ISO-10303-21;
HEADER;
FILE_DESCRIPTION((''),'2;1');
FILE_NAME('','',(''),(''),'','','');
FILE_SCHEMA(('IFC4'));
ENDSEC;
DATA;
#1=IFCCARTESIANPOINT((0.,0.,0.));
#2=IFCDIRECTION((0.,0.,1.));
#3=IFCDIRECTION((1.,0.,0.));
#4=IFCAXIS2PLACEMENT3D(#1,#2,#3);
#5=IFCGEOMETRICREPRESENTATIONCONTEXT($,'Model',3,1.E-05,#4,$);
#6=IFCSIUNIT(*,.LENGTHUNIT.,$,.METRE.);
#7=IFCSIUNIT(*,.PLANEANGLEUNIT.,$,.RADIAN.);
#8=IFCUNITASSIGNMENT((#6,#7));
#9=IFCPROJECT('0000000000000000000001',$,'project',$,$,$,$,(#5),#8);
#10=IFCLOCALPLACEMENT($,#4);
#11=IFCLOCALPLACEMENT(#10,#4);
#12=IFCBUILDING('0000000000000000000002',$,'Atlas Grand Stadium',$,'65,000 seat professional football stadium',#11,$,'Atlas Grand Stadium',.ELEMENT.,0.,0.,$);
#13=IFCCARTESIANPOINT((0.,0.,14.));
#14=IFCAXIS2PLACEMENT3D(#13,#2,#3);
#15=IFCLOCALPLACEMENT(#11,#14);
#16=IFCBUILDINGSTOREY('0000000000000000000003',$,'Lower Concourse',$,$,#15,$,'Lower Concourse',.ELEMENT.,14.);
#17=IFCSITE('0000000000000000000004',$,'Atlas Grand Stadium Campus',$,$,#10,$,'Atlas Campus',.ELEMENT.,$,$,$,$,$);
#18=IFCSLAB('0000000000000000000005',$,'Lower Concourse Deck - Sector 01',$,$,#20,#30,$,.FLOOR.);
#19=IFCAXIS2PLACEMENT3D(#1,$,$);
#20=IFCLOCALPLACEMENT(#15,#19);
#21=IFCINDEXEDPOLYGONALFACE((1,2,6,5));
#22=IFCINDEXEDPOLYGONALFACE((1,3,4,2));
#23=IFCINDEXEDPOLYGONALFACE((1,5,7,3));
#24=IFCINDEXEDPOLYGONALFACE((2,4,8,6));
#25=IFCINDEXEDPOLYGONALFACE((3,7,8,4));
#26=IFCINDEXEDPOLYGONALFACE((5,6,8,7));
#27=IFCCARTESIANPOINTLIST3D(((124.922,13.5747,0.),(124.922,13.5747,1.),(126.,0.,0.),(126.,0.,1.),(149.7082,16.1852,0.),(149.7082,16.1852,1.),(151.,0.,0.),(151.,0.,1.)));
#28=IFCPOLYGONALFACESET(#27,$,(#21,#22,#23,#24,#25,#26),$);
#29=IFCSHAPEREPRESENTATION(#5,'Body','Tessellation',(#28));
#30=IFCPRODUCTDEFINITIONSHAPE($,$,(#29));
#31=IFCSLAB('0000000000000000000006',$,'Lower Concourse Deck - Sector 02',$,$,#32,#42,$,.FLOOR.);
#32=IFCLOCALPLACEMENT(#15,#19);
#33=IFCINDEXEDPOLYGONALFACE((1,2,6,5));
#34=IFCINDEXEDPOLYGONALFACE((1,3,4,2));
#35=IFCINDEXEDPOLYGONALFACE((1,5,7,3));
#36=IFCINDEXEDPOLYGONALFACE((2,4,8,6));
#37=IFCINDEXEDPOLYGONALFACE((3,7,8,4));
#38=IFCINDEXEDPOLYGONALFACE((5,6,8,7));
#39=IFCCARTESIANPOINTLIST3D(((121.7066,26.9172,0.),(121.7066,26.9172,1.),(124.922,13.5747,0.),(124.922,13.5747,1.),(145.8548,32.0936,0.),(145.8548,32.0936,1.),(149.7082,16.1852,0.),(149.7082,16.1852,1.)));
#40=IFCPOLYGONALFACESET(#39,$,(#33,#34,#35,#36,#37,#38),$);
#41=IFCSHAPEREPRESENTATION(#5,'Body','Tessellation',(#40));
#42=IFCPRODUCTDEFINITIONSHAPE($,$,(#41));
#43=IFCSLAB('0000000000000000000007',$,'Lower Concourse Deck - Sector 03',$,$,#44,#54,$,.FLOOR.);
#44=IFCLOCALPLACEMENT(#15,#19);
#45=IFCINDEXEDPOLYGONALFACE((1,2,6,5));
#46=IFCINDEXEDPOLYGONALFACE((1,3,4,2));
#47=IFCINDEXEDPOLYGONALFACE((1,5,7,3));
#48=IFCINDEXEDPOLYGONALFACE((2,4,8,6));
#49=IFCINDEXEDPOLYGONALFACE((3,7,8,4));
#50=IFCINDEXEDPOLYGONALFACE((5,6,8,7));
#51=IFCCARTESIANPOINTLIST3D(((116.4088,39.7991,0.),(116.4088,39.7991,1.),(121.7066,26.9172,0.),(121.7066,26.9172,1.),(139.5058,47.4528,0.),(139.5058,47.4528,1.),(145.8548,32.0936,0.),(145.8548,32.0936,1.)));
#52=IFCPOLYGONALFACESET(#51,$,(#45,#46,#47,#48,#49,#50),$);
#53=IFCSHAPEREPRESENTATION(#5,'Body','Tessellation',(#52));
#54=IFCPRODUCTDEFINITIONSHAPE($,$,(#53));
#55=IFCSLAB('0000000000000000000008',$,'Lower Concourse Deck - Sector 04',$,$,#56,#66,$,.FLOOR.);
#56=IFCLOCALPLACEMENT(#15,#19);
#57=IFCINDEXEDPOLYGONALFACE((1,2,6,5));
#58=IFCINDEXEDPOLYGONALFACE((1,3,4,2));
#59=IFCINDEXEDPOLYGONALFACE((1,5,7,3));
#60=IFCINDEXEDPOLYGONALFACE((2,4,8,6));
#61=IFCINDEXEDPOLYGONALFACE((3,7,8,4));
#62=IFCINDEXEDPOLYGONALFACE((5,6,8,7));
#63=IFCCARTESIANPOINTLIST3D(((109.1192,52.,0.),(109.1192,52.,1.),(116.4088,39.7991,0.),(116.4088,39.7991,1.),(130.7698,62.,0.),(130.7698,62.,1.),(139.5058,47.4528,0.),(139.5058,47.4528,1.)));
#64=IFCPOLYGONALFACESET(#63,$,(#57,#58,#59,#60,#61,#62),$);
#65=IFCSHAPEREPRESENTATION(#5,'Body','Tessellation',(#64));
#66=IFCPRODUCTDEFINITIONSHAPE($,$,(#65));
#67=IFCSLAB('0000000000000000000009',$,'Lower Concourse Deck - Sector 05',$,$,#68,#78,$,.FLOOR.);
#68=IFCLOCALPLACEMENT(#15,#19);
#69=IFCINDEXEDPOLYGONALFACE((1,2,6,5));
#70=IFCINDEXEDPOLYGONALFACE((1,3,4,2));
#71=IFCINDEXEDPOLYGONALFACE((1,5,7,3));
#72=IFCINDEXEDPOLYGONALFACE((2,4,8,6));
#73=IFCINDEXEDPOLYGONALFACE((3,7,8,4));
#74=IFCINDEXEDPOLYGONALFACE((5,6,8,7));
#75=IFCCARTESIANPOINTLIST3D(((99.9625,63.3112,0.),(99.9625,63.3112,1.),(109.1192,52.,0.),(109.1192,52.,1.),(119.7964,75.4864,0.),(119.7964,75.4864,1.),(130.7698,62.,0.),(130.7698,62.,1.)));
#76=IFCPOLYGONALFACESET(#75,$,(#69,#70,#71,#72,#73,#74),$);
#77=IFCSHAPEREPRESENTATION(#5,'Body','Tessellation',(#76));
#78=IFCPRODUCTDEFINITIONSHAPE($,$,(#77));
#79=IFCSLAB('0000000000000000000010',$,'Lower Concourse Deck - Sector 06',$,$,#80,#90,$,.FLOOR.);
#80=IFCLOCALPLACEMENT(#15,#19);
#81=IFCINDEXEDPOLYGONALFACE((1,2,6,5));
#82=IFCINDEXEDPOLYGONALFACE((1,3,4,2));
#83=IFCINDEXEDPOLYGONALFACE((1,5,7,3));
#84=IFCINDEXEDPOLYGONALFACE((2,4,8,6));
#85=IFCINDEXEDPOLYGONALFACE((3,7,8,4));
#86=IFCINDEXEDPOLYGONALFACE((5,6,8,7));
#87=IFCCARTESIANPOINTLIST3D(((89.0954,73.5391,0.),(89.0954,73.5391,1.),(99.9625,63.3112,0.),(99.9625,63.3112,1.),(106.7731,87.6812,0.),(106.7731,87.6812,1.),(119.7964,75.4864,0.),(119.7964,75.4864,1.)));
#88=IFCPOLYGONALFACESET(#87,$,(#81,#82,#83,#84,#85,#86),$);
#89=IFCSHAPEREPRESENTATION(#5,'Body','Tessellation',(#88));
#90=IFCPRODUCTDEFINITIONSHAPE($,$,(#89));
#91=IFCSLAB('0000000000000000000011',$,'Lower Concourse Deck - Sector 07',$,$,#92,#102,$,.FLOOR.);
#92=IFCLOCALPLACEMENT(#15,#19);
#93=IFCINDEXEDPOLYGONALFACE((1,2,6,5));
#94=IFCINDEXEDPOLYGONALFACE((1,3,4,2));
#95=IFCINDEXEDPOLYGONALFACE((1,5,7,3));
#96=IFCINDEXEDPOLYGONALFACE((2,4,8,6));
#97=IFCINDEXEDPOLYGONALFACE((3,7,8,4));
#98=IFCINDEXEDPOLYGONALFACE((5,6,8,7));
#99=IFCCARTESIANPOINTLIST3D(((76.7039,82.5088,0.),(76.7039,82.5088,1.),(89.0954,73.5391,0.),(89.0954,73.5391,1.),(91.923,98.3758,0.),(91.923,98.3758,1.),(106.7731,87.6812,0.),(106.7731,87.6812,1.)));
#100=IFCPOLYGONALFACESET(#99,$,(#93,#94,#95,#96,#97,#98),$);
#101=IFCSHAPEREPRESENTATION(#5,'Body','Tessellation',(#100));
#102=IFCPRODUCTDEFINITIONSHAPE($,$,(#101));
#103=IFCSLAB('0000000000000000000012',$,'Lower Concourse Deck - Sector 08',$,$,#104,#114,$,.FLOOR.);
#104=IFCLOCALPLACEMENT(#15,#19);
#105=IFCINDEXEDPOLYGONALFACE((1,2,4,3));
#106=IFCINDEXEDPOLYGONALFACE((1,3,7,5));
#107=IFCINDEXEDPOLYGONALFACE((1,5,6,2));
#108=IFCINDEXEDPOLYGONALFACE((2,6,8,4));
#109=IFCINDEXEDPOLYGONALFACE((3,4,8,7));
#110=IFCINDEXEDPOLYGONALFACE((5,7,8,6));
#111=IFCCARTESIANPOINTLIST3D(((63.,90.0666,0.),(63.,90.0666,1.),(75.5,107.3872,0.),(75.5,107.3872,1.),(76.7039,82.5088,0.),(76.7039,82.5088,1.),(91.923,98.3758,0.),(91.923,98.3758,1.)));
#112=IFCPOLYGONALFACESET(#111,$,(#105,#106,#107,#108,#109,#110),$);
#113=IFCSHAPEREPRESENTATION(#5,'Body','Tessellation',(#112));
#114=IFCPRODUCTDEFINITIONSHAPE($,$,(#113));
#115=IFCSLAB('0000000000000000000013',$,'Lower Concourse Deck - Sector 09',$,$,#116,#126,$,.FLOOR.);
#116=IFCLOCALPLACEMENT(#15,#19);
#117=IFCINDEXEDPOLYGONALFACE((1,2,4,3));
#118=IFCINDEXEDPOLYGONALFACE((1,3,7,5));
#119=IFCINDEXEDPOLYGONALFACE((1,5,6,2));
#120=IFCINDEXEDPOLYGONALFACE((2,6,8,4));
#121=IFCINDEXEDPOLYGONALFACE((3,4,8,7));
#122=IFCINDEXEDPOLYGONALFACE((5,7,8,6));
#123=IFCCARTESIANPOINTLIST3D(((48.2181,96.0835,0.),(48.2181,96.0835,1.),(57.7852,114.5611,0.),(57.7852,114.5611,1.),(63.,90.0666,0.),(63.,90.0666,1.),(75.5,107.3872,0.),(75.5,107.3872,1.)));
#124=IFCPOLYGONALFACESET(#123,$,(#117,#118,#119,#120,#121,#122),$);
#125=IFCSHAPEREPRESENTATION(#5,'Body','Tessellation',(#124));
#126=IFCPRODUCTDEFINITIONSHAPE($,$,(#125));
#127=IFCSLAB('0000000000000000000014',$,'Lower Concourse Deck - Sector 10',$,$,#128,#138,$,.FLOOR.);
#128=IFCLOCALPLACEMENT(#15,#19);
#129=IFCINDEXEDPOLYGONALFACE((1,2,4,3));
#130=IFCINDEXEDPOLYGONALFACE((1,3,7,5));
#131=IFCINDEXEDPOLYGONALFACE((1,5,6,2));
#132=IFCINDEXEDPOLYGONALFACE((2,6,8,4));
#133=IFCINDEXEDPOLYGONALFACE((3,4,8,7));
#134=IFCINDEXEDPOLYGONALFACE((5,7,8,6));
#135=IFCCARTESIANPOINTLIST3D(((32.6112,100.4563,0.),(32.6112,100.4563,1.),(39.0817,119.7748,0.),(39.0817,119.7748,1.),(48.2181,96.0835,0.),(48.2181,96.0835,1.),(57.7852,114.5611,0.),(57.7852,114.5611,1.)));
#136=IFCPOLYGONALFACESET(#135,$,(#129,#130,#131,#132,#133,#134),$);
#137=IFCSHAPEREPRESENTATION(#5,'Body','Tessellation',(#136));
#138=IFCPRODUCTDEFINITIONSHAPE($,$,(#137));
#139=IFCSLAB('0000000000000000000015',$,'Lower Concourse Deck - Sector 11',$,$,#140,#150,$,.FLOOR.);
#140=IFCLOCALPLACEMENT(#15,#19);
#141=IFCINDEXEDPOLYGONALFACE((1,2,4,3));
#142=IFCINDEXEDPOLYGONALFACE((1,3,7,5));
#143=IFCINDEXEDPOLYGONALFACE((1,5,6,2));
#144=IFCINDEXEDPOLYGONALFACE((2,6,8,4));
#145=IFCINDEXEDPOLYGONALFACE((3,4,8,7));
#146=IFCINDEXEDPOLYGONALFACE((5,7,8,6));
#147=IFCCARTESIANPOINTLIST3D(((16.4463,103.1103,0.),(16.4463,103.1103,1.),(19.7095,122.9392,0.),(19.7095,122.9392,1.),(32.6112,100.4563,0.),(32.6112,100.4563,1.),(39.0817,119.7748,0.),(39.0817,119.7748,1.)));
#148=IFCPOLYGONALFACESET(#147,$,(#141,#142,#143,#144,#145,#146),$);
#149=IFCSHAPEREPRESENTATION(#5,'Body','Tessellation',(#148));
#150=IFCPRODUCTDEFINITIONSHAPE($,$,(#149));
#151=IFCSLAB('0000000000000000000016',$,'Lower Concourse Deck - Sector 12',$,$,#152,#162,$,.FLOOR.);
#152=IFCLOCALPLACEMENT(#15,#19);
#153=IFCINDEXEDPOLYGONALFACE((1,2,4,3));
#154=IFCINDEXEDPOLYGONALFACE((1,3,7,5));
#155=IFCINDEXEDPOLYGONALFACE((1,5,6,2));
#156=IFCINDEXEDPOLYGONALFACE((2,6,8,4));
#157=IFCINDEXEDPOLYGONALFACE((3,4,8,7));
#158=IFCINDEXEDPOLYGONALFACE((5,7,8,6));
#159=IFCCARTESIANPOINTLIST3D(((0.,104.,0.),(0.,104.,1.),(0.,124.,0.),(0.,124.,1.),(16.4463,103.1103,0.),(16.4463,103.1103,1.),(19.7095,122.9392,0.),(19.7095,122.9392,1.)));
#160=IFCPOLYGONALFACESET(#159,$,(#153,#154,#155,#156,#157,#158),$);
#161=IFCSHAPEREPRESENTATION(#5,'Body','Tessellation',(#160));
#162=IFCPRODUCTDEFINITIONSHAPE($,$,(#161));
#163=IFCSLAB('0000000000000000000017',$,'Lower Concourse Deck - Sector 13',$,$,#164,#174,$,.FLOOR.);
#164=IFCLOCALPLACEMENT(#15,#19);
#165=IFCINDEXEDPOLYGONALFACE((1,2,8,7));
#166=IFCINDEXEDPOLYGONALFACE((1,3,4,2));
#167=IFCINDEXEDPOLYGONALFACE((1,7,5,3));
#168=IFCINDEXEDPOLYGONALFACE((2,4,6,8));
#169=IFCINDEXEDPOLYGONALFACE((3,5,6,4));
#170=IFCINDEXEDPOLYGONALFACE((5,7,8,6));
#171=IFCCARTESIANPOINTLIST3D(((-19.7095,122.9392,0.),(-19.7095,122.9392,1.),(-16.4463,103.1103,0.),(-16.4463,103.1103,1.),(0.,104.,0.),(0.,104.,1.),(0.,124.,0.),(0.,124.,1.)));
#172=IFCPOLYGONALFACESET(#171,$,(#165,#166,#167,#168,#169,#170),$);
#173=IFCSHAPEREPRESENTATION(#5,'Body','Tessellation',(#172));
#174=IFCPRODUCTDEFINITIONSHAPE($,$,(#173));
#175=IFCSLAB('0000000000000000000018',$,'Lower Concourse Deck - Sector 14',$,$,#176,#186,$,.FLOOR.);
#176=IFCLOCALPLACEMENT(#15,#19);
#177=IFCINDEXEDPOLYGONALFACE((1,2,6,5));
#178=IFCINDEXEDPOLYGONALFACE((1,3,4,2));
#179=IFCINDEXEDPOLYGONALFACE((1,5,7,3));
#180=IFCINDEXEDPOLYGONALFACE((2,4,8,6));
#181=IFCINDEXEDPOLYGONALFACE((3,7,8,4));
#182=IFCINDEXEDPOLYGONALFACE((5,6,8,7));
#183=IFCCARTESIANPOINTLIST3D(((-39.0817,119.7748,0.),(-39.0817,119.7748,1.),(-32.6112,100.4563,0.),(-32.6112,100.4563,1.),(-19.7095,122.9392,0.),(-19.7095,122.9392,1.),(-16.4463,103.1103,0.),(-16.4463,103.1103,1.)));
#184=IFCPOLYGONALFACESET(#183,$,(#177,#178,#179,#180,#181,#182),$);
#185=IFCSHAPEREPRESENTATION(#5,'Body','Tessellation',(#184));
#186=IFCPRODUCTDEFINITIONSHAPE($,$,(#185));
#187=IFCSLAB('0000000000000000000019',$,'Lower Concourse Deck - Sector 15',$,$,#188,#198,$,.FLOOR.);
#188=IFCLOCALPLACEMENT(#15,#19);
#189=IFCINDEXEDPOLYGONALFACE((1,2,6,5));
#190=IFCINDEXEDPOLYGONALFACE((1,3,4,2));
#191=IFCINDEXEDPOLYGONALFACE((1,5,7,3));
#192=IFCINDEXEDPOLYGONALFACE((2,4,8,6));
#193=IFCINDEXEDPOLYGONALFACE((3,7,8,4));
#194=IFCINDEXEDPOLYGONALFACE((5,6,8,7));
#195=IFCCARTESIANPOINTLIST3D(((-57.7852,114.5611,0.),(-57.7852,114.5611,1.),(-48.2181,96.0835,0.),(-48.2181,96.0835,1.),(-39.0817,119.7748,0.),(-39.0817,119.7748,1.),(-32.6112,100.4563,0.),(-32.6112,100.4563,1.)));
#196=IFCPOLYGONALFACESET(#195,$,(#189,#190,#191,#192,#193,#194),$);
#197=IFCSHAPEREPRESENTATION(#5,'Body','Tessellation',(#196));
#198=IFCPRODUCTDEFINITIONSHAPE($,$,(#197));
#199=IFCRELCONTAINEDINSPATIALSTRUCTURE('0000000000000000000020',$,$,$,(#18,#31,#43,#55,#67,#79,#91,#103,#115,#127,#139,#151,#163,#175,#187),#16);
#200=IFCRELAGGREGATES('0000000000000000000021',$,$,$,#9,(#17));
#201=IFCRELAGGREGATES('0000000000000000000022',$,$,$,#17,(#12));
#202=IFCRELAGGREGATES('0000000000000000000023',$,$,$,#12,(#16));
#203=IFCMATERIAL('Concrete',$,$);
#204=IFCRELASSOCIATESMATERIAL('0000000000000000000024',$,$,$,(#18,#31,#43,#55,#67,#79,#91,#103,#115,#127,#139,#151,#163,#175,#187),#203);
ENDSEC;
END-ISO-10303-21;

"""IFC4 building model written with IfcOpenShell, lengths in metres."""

from ifc_helpers import new_model, si_unit, frame, origin_with_axes, place, context, project, spatial, polyline, outline, extrude, material, element, save


model = new_model("IFC4")

# Units and contexts
model_context = context("Model", 3, precision=1e-05, world=origin_with_axes())
ifc_project = project(units=[si_unit("LENGTHUNIT", "METRE"), si_unit("PLANEANGLEUNIT", "RADIAN")], contexts=[model_context])

# Site, building, storey
site_placement = place(None, origin_with_axes())
site = spatial("IfcSite", under=ifc_project, at=site_placement, Name="Atlas Grand Stadium Campus", LongName="Atlas Campus", CompositionType="ELEMENT")
building_placement = place(site_placement, origin_with_axes())
building = spatial("IfcBuilding", under=site, at=building_placement, Name="Atlas Grand Stadium", ObjectType="65,000 seat professional football stadium", LongName="Atlas Grand Stadium", CompositionType="ELEMENT", ElevationOfRefHeight=0.0, ElevationOfTerrain=0.0)
storey_placement = place(building_placement, frame((0.0, 0.0, 14.0), z_axis=(0.0, 0.0, 1.0), x_axis=(1.0, 0.0, 0.0)))
storey = spatial("IfcBuildingStorey", under=building, at=storey_placement, Name="Lower Concourse", LongName="Lower Concourse", CompositionType="ELEMENT", Elevation=14.0)

# Slabs
ifc_material = material(Name="Concrete")
slab_1_placement = place(storey_placement, origin_with_axes())
element("IfcSlab", 1, at=slab_1_placement, inside=storey, material=ifc_material, Name="Lower Concourse Deck - Sector 01", PredefinedType="FLOOR", context=model_context, shape_type="SweptSolid", body=[
    extrude(outline(polyline([(151.0, 0.0), (149.7082, 16.1852), (124.922, 13.5747), (126.0, 0.0), (151.0, 0.0)])), origin_with_axes(), (0.0, 0.0, 1.0), 1.0),
])
slab_2_placement = place(storey_placement, origin_with_axes())
element("IfcSlab", 2, at=slab_2_placement, inside=storey, material=ifc_material, Name="Lower Concourse Deck - Sector 02", PredefinedType="FLOOR", context=model_context, shape_type="SweptSolid", body=[
    extrude(outline(polyline([(149.7082, 16.1852), (145.8548, 32.0936), (121.7066, 26.9172), (124.922, 13.5747), (149.7082, 16.1852)])), origin_with_axes(), (0.0, 0.0, 1.0), 1.0),
])
slab_3_placement = place(storey_placement, origin_with_axes())
element("IfcSlab", 3, at=slab_3_placement, inside=storey, material=ifc_material, Name="Lower Concourse Deck - Sector 03", PredefinedType="FLOOR", context=model_context, shape_type="SweptSolid", body=[
    extrude(outline(polyline([(145.8548, 32.0936), (139.5058, 47.4528), (116.4088, 39.7991), (121.7066, 26.9172), (145.8548, 32.0936)])), origin_with_axes(), (0.0, 0.0, 1.0), 1.0),
])
slab_4_placement = place(storey_placement, origin_with_axes())
element("IfcSlab", 4, at=slab_4_placement, inside=storey, material=ifc_material, Name="Lower Concourse Deck - Sector 04", PredefinedType="FLOOR", context=model_context, shape_type="SweptSolid", body=[
    extrude(outline(polyline([(139.5058, 47.4528), (130.7698, 62.0), (109.1192, 52.0), (116.4088, 39.7991), (139.5058, 47.4528)])), origin_with_axes(), (0.0, 0.0, 1.0), 1.0),
])
slab_5_placement = place(storey_placement, origin_with_axes())
element("IfcSlab", 5, at=slab_5_placement, inside=storey, material=ifc_material, Name="Lower Concourse Deck - Sector 05", PredefinedType="FLOOR", context=model_context, shape_type="SweptSolid", body=[
    extrude(outline(polyline([(130.7698, 62.0), (119.7964, 75.4864), (99.9625, 63.3112), (109.1192, 52.0), (130.7698, 62.0)])), origin_with_axes(), (0.0, 0.0, 1.0), 1.0),
])
slab_6_placement = place(storey_placement, origin_with_axes())
element("IfcSlab", 6, at=slab_6_placement, inside=storey, material=ifc_material, Name="Lower Concourse Deck - Sector 06", PredefinedType="FLOOR", context=model_context, shape_type="SweptSolid", body=[
    extrude(outline(polyline([(119.7964, 75.4864), (106.7731, 87.6812), (89.0954, 73.5391), (99.9625, 63.3112), (119.7964, 75.4864)])), origin_with_axes(), (0.0, 0.0, 1.0), 1.0),
])
slab_7_placement = place(storey_placement, origin_with_axes())
element("IfcSlab", 7, at=slab_7_placement, inside=storey, material=ifc_material, Name="Lower Concourse Deck - Sector 07", PredefinedType="FLOOR", context=model_context, shape_type="SweptSolid", body=[
    extrude(outline(polyline([(106.7731, 87.6812), (91.923, 98.3758), (76.7039, 82.5088), (89.0954, 73.5391), (106.7731, 87.6812)])), origin_with_axes(), (0.0, 0.0, 1.0), 1.0),
])
slab_8_placement = place(storey_placement, origin_with_axes())
element("IfcSlab", 8, at=slab_8_placement, inside=storey, material=ifc_material, Name="Lower Concourse Deck - Sector 08", PredefinedType="FLOOR", context=model_context, shape_type="SweptSolid", body=[
    extrude(outline(polyline([(91.923, 98.3758), (75.5, 107.3872), (63.0, 90.0666), (76.7039, 82.5088), (91.923, 98.3758)])), origin_with_axes(), (0.0, 0.0, 1.0), 1.0),
])
slab_9_placement = place(storey_placement, origin_with_axes())
element("IfcSlab", 9, at=slab_9_placement, inside=storey, material=ifc_material, Name="Lower Concourse Deck - Sector 09", PredefinedType="FLOOR", context=model_context, shape_type="SweptSolid", body=[
    extrude(outline(polyline([(75.5, 107.3872), (57.7852, 114.5611), (48.2181, 96.0835), (63.0, 90.0666), (75.5, 107.3872)])), origin_with_axes(), (0.0, 0.0, 1.0), 1.0),
])
slab_10_placement = place(storey_placement, origin_with_axes())
element("IfcSlab", 10, at=slab_10_placement, inside=storey, material=ifc_material, Name="Lower Concourse Deck - Sector 10", PredefinedType="FLOOR", context=model_context, shape_type="SweptSolid", body=[
    extrude(outline(polyline([(57.7852, 114.5611), (39.0817, 119.7748), (32.6112, 100.4563), (48.2181, 96.0835), (57.7852, 114.5611)])), origin_with_axes(), (0.0, 0.0, 1.0), 1.0),
])
slab_11_placement = place(storey_placement, origin_with_axes())
element("IfcSlab", 11, at=slab_11_placement, inside=storey, material=ifc_material, Name="Lower Concourse Deck - Sector 11", PredefinedType="FLOOR", context=model_context, shape_type="SweptSolid", body=[
    extrude(outline(polyline([(39.0817, 119.7748), (19.7095, 122.9392), (16.4463, 103.1103), (32.6112, 100.4563), (39.0817, 119.7748)])), origin_with_axes(), (0.0, 0.0, 1.0), 1.0),
])
slab_12_placement = place(storey_placement, origin_with_axes())
element("IfcSlab", 12, at=slab_12_placement, inside=storey, material=ifc_material, Name="Lower Concourse Deck - Sector 12", PredefinedType="FLOOR", context=model_context, shape_type="SweptSolid", body=[
    extrude(outline(polyline([(19.7095, 122.9392), (0.0, 124.0), (0.0, 104.0), (16.4463, 103.1103), (19.7095, 122.9392)])), origin_with_axes(), (0.0, 0.0, 1.0), 1.0),
])
slab_13_placement = place(storey_placement, origin_with_axes())
element("IfcSlab", 13, at=slab_13_placement, inside=storey, material=ifc_material, Name="Lower Concourse Deck - Sector 13", PredefinedType="FLOOR", context=model_context, shape_type="SweptSolid", body=[
    extrude(outline(polyline([(0.0, 124.0), (-19.7095, 122.9392), (-16.4463, 103.1103), (0.0, 104.0), (0.0, 124.0)])), origin_with_axes(), (0.0, 0.0, 1.0), 1.0),
])
slab_14_placement = place(storey_placement, origin_with_axes())
element("IfcSlab", 14, at=slab_14_placement, inside=storey, material=ifc_material, Name="Lower Concourse Deck - Sector 14", PredefinedType="FLOOR", context=model_context, shape_type="SweptSolid", body=[
    extrude(outline(polyline([(-19.7095, 122.9392), (-39.0817, 119.7748), (-32.6112, 100.4563), (-16.4463, 103.1103), (-19.7095, 122.9392)])), origin_with_axes(), (0.0, 0.0, 1.0), 1.0),
])
slab_15_placement = place(storey_placement, origin_with_axes())
element("IfcSlab", 15, at=slab_15_placement, inside=storey, material=ifc_material, Name="Lower Concourse Deck - Sector 15", PredefinedType="FLOOR", context=model_context, shape_type="SweptSolid", body=[
    extrude(outline(polyline([(-39.0817, 119.7748), (-57.7852, 114.5611), (-48.2181, 96.0835), (-32.6112, 100.4563), (-39.0817, 119.7748)])), origin_with_axes(), (0.0, 0.0, 1.0), 1.0),
])

save(model, "model.ifc")
